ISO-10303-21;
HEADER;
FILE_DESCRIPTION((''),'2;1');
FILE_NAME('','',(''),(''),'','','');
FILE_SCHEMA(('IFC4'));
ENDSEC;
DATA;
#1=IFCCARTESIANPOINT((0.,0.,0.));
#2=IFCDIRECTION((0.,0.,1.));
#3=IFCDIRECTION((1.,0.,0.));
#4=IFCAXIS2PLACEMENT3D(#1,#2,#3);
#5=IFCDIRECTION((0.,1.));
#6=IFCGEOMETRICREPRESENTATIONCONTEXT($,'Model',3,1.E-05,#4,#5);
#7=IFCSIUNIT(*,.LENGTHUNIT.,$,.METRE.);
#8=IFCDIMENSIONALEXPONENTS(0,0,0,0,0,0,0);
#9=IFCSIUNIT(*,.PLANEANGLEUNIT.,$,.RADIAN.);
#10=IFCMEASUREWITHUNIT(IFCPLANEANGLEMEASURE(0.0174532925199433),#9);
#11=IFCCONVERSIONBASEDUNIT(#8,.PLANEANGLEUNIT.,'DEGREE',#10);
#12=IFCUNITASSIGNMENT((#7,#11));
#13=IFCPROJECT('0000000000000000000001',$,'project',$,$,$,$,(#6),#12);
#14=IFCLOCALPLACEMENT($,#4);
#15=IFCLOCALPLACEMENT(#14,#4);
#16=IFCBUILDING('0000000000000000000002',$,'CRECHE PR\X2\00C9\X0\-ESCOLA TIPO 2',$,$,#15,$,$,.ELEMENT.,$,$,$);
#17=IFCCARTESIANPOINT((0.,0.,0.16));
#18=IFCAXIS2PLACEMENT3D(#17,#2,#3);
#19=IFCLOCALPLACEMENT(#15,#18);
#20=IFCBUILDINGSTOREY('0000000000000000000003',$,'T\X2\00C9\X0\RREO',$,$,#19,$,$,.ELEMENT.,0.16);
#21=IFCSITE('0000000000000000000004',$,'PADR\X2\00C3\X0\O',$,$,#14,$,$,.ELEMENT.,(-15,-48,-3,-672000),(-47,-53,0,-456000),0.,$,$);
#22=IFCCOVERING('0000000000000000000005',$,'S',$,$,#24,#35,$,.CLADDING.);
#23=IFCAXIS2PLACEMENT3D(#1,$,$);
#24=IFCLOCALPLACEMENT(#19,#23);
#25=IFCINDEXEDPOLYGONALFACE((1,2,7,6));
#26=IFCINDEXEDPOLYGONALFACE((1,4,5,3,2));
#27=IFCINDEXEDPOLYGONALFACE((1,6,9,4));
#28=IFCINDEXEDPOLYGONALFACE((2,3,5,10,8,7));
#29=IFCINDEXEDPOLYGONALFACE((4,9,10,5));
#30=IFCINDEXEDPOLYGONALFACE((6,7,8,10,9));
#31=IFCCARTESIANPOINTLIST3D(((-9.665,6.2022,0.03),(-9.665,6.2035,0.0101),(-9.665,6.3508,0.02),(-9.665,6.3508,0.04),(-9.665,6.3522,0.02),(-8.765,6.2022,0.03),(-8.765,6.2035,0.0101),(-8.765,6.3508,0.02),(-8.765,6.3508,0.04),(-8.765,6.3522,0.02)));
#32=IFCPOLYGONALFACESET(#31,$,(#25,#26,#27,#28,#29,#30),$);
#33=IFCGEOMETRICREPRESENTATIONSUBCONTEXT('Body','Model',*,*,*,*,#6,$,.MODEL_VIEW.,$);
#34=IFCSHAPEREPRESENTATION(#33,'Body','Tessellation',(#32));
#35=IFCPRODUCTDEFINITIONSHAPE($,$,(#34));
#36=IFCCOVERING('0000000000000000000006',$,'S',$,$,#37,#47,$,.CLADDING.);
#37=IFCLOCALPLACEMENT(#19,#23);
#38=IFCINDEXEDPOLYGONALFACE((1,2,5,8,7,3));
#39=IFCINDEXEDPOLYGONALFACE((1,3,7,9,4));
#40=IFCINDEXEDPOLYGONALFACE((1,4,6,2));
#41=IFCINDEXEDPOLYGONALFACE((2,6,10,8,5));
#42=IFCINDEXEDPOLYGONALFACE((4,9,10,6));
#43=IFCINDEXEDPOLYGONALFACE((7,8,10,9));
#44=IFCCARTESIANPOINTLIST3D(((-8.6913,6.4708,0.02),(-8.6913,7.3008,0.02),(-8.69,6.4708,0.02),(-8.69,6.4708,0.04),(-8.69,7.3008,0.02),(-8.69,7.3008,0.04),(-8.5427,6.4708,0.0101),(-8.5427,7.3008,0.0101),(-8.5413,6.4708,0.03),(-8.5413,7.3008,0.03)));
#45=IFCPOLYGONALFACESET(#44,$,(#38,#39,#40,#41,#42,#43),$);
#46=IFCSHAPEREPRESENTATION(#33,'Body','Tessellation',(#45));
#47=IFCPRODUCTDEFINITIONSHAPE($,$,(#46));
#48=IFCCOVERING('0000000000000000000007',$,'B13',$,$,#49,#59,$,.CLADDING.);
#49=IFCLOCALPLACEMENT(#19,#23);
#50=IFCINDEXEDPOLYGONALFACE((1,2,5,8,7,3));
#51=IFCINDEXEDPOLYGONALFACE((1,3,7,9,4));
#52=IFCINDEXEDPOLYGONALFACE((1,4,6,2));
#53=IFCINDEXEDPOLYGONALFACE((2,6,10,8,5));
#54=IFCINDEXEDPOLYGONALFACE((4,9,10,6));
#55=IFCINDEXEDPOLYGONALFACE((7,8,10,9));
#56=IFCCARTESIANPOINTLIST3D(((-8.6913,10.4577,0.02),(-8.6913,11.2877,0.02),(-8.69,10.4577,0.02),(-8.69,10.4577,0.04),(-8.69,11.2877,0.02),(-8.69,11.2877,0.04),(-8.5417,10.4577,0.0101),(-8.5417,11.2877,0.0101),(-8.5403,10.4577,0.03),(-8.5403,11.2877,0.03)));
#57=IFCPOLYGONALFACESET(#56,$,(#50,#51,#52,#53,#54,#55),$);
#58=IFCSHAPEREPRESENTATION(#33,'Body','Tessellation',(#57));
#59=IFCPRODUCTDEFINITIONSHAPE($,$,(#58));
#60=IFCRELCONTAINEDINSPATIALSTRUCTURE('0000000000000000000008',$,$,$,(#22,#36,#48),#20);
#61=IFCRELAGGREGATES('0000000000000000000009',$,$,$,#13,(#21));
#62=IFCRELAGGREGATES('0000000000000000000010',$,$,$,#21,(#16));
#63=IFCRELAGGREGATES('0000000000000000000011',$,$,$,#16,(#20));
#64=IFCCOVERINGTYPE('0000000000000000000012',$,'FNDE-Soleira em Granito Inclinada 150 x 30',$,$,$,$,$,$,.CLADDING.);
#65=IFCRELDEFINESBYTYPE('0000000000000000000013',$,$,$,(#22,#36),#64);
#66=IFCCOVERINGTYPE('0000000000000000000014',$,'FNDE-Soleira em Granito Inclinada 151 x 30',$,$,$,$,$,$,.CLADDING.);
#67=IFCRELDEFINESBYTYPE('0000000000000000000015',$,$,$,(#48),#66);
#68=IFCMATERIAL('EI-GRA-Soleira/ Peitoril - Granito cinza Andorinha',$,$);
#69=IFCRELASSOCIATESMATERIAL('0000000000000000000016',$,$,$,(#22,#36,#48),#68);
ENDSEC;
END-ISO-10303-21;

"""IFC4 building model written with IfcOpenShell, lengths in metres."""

from ifc_helpers import new_model, entity, si_unit, converted_unit, direction, frame, origin_with_axes, place, context, subcontext, project, spatial, line, indexed_curve, outline, extrude, material, material_profile, profile_set, type_object, element, save


model = new_model("IFC4")

# Units and contexts
model_context = context("Model", 3, precision=1e-05, world=origin_with_axes(), true_north=direction((0.0, 1.0)))
body_context = subcontext(model_context, "Body", "Model", "MODEL_VIEW")
ifc_project = project(units=[si_unit("LENGTHUNIT", "METRE"), converted_unit("PLANEANGLEUNIT", "DEGREE", entity("IfcPlaneAngleMeasure", 0.0174532925199433), si_unit("PLANEANGLEUNIT", "RADIAN"), dimensions=[0, 0, 0, 0, 0, 0, 0])], contexts=[model_context])

# Site, building, storey
site_placement = place(None, origin_with_axes())
site = spatial("IfcSite", under=ifc_project, at=site_placement, Name="PADRÃO", CompositionType="ELEMENT", RefLatitude=(-15, -48, -3, -672000), RefLongitude=(-47, -53, 0, -456000), RefElevation=0.0)
building_placement = place(site_placement, origin_with_axes())
building = spatial("IfcBuilding", under=site, at=building_placement, Name="CRECHE PRÉ-ESCOLA TIPO 2", CompositionType="ELEMENT")
storey_placement = place(building_placement, frame((0.0, 0.0, 0.16), z_axis=(0.0, 0.0, 1.0), x_axis=(1.0, 0.0, 0.0)))
storey = spatial("IfcBuildingStorey", under=building, at=storey_placement, Name="TÉRREO", CompositionType="ELEMENT", Elevation=0.16)

# Coverings
ifc_material_1 = material(Name="EI-GRA-Soleira/ Peitoril - Granito cinza Andorinha")
ifc_material_profile_1 = material_profile(ifc_material_1, outline(indexed_curve([(-0.0013, 0.02), (0.0, 0.02), (0.1474, 0.0101), (0.1487, 0.03), (0.0, 0.04)], segments=[line(1, 2, 3, 4, 5, 1)])), Name="EI-GRA-Soleira/ Peitoril - Granito cinza Andorinha")
ifc_profile_set_1 = profile_set([ifc_material_profile_1], Name="FNDE-Soleira em Granito Inclinada")
covering_type_1 = type_object("IfcCoveringType", Name="FNDE-Soleira em Granito Inclinada 150 x 30", PredefinedType="CLADDING")
covering_1_placement = place(storey_placement, frame((-9.665, 6.3508, 0.0), z_axis=(0.0, 0.0, 1.0), x_axis=(0.0, -1.0, 0.0)))
element("IfcCovering", 1, at=covering_1_placement, inside=storey, type_object=covering_type_1, material=ifc_profile_set_1, Name="S", PredefinedType="CLADDING", context=body_context, shape_type="SweptSolid", body=[
    extrude(outline(indexed_curve([(-0.0013, 0.02), (0.0, 0.02), (0.1474, 0.0101), (0.1487, 0.03), (0.0, 0.04)], segments=[line(1, 2, 3, 4, 5, 1)])), frame((0.0, 0.9, 0.0), z_axis=(0.0, -1.0, 0.0), x_axis=(1.0, 0.0, 0.0)), (0.0, 0.0, 1.0), 0.9),
])
covering_2_placement = place(storey_placement, frame((-8.69, 6.4708, 0.0), z_axis=(0.0, 0.0, 1.0), x_axis=(1.0, 0.0, 0.0)))
element("IfcCovering", 2, at=covering_2_placement, inside=storey, type_object=covering_type_1, material=ifc_profile_set_1, Name="S", PredefinedType="CLADDING", context=body_context, shape_type="SweptSolid", body=[
    extrude(outline(indexed_curve([(-0.0013, 0.02), (0.0, 0.02), (0.1474, 0.0101), (0.1487, 0.03), (0.0, 0.04)], segments=[line(1, 2, 3, 4, 5, 1)])), frame((0.0, 0.83, 0.0), z_axis=(0.0, -1.0, 0.0), x_axis=(1.0, 0.0, 0.0)), (0.0, 0.0, 1.0), 0.83),
])
ifc_material_profile_2 = material_profile(ifc_material_1, outline(indexed_curve([(-0.0013, 0.02), (0.0, 0.02), (0.1483, 0.0101), (0.1497, 0.03), (0.0, 0.04)], segments=[line(1, 2, 3, 4, 5, 1)])), Name="EI-GRA-Soleira/ Peitoril - Granito cinza Andorinha")
ifc_profile_set_2 = profile_set([ifc_material_profile_2], Name="FNDE-Soleira em Granito Inclinada")
covering_type_2 = type_object("IfcCoveringType", Name="FNDE-Soleira em Granito Inclinada 151 x 30", PredefinedType="CLADDING")
covering_3_placement = place(storey_placement, frame((-8.69, 10.4577, 0.0), z_axis=(0.0, 0.0, 1.0), x_axis=(1.0, 0.0, 0.0)))
element("IfcCovering", 3, at=covering_3_placement, inside=storey, type_object=covering_type_2, material=ifc_profile_set_2, Name="B13", PredefinedType="CLADDING", context=body_context, shape_type="SweptSolid", body=[
    extrude(outline(indexed_curve([(-0.0013, 0.02), (0.0, 0.02), (0.1483, 0.0101), (0.1497, 0.03), (0.0, 0.04)], segments=[line(1, 2, 3, 4, 5, 1)])), frame((0.0, 0.83, 0.0), z_axis=(0.0, -1.0, 0.0), x_axis=(1.0, 0.0, 0.0)), (0.0, 0.0, 1.0), 0.83),
])

save(model, "model.ifc")
